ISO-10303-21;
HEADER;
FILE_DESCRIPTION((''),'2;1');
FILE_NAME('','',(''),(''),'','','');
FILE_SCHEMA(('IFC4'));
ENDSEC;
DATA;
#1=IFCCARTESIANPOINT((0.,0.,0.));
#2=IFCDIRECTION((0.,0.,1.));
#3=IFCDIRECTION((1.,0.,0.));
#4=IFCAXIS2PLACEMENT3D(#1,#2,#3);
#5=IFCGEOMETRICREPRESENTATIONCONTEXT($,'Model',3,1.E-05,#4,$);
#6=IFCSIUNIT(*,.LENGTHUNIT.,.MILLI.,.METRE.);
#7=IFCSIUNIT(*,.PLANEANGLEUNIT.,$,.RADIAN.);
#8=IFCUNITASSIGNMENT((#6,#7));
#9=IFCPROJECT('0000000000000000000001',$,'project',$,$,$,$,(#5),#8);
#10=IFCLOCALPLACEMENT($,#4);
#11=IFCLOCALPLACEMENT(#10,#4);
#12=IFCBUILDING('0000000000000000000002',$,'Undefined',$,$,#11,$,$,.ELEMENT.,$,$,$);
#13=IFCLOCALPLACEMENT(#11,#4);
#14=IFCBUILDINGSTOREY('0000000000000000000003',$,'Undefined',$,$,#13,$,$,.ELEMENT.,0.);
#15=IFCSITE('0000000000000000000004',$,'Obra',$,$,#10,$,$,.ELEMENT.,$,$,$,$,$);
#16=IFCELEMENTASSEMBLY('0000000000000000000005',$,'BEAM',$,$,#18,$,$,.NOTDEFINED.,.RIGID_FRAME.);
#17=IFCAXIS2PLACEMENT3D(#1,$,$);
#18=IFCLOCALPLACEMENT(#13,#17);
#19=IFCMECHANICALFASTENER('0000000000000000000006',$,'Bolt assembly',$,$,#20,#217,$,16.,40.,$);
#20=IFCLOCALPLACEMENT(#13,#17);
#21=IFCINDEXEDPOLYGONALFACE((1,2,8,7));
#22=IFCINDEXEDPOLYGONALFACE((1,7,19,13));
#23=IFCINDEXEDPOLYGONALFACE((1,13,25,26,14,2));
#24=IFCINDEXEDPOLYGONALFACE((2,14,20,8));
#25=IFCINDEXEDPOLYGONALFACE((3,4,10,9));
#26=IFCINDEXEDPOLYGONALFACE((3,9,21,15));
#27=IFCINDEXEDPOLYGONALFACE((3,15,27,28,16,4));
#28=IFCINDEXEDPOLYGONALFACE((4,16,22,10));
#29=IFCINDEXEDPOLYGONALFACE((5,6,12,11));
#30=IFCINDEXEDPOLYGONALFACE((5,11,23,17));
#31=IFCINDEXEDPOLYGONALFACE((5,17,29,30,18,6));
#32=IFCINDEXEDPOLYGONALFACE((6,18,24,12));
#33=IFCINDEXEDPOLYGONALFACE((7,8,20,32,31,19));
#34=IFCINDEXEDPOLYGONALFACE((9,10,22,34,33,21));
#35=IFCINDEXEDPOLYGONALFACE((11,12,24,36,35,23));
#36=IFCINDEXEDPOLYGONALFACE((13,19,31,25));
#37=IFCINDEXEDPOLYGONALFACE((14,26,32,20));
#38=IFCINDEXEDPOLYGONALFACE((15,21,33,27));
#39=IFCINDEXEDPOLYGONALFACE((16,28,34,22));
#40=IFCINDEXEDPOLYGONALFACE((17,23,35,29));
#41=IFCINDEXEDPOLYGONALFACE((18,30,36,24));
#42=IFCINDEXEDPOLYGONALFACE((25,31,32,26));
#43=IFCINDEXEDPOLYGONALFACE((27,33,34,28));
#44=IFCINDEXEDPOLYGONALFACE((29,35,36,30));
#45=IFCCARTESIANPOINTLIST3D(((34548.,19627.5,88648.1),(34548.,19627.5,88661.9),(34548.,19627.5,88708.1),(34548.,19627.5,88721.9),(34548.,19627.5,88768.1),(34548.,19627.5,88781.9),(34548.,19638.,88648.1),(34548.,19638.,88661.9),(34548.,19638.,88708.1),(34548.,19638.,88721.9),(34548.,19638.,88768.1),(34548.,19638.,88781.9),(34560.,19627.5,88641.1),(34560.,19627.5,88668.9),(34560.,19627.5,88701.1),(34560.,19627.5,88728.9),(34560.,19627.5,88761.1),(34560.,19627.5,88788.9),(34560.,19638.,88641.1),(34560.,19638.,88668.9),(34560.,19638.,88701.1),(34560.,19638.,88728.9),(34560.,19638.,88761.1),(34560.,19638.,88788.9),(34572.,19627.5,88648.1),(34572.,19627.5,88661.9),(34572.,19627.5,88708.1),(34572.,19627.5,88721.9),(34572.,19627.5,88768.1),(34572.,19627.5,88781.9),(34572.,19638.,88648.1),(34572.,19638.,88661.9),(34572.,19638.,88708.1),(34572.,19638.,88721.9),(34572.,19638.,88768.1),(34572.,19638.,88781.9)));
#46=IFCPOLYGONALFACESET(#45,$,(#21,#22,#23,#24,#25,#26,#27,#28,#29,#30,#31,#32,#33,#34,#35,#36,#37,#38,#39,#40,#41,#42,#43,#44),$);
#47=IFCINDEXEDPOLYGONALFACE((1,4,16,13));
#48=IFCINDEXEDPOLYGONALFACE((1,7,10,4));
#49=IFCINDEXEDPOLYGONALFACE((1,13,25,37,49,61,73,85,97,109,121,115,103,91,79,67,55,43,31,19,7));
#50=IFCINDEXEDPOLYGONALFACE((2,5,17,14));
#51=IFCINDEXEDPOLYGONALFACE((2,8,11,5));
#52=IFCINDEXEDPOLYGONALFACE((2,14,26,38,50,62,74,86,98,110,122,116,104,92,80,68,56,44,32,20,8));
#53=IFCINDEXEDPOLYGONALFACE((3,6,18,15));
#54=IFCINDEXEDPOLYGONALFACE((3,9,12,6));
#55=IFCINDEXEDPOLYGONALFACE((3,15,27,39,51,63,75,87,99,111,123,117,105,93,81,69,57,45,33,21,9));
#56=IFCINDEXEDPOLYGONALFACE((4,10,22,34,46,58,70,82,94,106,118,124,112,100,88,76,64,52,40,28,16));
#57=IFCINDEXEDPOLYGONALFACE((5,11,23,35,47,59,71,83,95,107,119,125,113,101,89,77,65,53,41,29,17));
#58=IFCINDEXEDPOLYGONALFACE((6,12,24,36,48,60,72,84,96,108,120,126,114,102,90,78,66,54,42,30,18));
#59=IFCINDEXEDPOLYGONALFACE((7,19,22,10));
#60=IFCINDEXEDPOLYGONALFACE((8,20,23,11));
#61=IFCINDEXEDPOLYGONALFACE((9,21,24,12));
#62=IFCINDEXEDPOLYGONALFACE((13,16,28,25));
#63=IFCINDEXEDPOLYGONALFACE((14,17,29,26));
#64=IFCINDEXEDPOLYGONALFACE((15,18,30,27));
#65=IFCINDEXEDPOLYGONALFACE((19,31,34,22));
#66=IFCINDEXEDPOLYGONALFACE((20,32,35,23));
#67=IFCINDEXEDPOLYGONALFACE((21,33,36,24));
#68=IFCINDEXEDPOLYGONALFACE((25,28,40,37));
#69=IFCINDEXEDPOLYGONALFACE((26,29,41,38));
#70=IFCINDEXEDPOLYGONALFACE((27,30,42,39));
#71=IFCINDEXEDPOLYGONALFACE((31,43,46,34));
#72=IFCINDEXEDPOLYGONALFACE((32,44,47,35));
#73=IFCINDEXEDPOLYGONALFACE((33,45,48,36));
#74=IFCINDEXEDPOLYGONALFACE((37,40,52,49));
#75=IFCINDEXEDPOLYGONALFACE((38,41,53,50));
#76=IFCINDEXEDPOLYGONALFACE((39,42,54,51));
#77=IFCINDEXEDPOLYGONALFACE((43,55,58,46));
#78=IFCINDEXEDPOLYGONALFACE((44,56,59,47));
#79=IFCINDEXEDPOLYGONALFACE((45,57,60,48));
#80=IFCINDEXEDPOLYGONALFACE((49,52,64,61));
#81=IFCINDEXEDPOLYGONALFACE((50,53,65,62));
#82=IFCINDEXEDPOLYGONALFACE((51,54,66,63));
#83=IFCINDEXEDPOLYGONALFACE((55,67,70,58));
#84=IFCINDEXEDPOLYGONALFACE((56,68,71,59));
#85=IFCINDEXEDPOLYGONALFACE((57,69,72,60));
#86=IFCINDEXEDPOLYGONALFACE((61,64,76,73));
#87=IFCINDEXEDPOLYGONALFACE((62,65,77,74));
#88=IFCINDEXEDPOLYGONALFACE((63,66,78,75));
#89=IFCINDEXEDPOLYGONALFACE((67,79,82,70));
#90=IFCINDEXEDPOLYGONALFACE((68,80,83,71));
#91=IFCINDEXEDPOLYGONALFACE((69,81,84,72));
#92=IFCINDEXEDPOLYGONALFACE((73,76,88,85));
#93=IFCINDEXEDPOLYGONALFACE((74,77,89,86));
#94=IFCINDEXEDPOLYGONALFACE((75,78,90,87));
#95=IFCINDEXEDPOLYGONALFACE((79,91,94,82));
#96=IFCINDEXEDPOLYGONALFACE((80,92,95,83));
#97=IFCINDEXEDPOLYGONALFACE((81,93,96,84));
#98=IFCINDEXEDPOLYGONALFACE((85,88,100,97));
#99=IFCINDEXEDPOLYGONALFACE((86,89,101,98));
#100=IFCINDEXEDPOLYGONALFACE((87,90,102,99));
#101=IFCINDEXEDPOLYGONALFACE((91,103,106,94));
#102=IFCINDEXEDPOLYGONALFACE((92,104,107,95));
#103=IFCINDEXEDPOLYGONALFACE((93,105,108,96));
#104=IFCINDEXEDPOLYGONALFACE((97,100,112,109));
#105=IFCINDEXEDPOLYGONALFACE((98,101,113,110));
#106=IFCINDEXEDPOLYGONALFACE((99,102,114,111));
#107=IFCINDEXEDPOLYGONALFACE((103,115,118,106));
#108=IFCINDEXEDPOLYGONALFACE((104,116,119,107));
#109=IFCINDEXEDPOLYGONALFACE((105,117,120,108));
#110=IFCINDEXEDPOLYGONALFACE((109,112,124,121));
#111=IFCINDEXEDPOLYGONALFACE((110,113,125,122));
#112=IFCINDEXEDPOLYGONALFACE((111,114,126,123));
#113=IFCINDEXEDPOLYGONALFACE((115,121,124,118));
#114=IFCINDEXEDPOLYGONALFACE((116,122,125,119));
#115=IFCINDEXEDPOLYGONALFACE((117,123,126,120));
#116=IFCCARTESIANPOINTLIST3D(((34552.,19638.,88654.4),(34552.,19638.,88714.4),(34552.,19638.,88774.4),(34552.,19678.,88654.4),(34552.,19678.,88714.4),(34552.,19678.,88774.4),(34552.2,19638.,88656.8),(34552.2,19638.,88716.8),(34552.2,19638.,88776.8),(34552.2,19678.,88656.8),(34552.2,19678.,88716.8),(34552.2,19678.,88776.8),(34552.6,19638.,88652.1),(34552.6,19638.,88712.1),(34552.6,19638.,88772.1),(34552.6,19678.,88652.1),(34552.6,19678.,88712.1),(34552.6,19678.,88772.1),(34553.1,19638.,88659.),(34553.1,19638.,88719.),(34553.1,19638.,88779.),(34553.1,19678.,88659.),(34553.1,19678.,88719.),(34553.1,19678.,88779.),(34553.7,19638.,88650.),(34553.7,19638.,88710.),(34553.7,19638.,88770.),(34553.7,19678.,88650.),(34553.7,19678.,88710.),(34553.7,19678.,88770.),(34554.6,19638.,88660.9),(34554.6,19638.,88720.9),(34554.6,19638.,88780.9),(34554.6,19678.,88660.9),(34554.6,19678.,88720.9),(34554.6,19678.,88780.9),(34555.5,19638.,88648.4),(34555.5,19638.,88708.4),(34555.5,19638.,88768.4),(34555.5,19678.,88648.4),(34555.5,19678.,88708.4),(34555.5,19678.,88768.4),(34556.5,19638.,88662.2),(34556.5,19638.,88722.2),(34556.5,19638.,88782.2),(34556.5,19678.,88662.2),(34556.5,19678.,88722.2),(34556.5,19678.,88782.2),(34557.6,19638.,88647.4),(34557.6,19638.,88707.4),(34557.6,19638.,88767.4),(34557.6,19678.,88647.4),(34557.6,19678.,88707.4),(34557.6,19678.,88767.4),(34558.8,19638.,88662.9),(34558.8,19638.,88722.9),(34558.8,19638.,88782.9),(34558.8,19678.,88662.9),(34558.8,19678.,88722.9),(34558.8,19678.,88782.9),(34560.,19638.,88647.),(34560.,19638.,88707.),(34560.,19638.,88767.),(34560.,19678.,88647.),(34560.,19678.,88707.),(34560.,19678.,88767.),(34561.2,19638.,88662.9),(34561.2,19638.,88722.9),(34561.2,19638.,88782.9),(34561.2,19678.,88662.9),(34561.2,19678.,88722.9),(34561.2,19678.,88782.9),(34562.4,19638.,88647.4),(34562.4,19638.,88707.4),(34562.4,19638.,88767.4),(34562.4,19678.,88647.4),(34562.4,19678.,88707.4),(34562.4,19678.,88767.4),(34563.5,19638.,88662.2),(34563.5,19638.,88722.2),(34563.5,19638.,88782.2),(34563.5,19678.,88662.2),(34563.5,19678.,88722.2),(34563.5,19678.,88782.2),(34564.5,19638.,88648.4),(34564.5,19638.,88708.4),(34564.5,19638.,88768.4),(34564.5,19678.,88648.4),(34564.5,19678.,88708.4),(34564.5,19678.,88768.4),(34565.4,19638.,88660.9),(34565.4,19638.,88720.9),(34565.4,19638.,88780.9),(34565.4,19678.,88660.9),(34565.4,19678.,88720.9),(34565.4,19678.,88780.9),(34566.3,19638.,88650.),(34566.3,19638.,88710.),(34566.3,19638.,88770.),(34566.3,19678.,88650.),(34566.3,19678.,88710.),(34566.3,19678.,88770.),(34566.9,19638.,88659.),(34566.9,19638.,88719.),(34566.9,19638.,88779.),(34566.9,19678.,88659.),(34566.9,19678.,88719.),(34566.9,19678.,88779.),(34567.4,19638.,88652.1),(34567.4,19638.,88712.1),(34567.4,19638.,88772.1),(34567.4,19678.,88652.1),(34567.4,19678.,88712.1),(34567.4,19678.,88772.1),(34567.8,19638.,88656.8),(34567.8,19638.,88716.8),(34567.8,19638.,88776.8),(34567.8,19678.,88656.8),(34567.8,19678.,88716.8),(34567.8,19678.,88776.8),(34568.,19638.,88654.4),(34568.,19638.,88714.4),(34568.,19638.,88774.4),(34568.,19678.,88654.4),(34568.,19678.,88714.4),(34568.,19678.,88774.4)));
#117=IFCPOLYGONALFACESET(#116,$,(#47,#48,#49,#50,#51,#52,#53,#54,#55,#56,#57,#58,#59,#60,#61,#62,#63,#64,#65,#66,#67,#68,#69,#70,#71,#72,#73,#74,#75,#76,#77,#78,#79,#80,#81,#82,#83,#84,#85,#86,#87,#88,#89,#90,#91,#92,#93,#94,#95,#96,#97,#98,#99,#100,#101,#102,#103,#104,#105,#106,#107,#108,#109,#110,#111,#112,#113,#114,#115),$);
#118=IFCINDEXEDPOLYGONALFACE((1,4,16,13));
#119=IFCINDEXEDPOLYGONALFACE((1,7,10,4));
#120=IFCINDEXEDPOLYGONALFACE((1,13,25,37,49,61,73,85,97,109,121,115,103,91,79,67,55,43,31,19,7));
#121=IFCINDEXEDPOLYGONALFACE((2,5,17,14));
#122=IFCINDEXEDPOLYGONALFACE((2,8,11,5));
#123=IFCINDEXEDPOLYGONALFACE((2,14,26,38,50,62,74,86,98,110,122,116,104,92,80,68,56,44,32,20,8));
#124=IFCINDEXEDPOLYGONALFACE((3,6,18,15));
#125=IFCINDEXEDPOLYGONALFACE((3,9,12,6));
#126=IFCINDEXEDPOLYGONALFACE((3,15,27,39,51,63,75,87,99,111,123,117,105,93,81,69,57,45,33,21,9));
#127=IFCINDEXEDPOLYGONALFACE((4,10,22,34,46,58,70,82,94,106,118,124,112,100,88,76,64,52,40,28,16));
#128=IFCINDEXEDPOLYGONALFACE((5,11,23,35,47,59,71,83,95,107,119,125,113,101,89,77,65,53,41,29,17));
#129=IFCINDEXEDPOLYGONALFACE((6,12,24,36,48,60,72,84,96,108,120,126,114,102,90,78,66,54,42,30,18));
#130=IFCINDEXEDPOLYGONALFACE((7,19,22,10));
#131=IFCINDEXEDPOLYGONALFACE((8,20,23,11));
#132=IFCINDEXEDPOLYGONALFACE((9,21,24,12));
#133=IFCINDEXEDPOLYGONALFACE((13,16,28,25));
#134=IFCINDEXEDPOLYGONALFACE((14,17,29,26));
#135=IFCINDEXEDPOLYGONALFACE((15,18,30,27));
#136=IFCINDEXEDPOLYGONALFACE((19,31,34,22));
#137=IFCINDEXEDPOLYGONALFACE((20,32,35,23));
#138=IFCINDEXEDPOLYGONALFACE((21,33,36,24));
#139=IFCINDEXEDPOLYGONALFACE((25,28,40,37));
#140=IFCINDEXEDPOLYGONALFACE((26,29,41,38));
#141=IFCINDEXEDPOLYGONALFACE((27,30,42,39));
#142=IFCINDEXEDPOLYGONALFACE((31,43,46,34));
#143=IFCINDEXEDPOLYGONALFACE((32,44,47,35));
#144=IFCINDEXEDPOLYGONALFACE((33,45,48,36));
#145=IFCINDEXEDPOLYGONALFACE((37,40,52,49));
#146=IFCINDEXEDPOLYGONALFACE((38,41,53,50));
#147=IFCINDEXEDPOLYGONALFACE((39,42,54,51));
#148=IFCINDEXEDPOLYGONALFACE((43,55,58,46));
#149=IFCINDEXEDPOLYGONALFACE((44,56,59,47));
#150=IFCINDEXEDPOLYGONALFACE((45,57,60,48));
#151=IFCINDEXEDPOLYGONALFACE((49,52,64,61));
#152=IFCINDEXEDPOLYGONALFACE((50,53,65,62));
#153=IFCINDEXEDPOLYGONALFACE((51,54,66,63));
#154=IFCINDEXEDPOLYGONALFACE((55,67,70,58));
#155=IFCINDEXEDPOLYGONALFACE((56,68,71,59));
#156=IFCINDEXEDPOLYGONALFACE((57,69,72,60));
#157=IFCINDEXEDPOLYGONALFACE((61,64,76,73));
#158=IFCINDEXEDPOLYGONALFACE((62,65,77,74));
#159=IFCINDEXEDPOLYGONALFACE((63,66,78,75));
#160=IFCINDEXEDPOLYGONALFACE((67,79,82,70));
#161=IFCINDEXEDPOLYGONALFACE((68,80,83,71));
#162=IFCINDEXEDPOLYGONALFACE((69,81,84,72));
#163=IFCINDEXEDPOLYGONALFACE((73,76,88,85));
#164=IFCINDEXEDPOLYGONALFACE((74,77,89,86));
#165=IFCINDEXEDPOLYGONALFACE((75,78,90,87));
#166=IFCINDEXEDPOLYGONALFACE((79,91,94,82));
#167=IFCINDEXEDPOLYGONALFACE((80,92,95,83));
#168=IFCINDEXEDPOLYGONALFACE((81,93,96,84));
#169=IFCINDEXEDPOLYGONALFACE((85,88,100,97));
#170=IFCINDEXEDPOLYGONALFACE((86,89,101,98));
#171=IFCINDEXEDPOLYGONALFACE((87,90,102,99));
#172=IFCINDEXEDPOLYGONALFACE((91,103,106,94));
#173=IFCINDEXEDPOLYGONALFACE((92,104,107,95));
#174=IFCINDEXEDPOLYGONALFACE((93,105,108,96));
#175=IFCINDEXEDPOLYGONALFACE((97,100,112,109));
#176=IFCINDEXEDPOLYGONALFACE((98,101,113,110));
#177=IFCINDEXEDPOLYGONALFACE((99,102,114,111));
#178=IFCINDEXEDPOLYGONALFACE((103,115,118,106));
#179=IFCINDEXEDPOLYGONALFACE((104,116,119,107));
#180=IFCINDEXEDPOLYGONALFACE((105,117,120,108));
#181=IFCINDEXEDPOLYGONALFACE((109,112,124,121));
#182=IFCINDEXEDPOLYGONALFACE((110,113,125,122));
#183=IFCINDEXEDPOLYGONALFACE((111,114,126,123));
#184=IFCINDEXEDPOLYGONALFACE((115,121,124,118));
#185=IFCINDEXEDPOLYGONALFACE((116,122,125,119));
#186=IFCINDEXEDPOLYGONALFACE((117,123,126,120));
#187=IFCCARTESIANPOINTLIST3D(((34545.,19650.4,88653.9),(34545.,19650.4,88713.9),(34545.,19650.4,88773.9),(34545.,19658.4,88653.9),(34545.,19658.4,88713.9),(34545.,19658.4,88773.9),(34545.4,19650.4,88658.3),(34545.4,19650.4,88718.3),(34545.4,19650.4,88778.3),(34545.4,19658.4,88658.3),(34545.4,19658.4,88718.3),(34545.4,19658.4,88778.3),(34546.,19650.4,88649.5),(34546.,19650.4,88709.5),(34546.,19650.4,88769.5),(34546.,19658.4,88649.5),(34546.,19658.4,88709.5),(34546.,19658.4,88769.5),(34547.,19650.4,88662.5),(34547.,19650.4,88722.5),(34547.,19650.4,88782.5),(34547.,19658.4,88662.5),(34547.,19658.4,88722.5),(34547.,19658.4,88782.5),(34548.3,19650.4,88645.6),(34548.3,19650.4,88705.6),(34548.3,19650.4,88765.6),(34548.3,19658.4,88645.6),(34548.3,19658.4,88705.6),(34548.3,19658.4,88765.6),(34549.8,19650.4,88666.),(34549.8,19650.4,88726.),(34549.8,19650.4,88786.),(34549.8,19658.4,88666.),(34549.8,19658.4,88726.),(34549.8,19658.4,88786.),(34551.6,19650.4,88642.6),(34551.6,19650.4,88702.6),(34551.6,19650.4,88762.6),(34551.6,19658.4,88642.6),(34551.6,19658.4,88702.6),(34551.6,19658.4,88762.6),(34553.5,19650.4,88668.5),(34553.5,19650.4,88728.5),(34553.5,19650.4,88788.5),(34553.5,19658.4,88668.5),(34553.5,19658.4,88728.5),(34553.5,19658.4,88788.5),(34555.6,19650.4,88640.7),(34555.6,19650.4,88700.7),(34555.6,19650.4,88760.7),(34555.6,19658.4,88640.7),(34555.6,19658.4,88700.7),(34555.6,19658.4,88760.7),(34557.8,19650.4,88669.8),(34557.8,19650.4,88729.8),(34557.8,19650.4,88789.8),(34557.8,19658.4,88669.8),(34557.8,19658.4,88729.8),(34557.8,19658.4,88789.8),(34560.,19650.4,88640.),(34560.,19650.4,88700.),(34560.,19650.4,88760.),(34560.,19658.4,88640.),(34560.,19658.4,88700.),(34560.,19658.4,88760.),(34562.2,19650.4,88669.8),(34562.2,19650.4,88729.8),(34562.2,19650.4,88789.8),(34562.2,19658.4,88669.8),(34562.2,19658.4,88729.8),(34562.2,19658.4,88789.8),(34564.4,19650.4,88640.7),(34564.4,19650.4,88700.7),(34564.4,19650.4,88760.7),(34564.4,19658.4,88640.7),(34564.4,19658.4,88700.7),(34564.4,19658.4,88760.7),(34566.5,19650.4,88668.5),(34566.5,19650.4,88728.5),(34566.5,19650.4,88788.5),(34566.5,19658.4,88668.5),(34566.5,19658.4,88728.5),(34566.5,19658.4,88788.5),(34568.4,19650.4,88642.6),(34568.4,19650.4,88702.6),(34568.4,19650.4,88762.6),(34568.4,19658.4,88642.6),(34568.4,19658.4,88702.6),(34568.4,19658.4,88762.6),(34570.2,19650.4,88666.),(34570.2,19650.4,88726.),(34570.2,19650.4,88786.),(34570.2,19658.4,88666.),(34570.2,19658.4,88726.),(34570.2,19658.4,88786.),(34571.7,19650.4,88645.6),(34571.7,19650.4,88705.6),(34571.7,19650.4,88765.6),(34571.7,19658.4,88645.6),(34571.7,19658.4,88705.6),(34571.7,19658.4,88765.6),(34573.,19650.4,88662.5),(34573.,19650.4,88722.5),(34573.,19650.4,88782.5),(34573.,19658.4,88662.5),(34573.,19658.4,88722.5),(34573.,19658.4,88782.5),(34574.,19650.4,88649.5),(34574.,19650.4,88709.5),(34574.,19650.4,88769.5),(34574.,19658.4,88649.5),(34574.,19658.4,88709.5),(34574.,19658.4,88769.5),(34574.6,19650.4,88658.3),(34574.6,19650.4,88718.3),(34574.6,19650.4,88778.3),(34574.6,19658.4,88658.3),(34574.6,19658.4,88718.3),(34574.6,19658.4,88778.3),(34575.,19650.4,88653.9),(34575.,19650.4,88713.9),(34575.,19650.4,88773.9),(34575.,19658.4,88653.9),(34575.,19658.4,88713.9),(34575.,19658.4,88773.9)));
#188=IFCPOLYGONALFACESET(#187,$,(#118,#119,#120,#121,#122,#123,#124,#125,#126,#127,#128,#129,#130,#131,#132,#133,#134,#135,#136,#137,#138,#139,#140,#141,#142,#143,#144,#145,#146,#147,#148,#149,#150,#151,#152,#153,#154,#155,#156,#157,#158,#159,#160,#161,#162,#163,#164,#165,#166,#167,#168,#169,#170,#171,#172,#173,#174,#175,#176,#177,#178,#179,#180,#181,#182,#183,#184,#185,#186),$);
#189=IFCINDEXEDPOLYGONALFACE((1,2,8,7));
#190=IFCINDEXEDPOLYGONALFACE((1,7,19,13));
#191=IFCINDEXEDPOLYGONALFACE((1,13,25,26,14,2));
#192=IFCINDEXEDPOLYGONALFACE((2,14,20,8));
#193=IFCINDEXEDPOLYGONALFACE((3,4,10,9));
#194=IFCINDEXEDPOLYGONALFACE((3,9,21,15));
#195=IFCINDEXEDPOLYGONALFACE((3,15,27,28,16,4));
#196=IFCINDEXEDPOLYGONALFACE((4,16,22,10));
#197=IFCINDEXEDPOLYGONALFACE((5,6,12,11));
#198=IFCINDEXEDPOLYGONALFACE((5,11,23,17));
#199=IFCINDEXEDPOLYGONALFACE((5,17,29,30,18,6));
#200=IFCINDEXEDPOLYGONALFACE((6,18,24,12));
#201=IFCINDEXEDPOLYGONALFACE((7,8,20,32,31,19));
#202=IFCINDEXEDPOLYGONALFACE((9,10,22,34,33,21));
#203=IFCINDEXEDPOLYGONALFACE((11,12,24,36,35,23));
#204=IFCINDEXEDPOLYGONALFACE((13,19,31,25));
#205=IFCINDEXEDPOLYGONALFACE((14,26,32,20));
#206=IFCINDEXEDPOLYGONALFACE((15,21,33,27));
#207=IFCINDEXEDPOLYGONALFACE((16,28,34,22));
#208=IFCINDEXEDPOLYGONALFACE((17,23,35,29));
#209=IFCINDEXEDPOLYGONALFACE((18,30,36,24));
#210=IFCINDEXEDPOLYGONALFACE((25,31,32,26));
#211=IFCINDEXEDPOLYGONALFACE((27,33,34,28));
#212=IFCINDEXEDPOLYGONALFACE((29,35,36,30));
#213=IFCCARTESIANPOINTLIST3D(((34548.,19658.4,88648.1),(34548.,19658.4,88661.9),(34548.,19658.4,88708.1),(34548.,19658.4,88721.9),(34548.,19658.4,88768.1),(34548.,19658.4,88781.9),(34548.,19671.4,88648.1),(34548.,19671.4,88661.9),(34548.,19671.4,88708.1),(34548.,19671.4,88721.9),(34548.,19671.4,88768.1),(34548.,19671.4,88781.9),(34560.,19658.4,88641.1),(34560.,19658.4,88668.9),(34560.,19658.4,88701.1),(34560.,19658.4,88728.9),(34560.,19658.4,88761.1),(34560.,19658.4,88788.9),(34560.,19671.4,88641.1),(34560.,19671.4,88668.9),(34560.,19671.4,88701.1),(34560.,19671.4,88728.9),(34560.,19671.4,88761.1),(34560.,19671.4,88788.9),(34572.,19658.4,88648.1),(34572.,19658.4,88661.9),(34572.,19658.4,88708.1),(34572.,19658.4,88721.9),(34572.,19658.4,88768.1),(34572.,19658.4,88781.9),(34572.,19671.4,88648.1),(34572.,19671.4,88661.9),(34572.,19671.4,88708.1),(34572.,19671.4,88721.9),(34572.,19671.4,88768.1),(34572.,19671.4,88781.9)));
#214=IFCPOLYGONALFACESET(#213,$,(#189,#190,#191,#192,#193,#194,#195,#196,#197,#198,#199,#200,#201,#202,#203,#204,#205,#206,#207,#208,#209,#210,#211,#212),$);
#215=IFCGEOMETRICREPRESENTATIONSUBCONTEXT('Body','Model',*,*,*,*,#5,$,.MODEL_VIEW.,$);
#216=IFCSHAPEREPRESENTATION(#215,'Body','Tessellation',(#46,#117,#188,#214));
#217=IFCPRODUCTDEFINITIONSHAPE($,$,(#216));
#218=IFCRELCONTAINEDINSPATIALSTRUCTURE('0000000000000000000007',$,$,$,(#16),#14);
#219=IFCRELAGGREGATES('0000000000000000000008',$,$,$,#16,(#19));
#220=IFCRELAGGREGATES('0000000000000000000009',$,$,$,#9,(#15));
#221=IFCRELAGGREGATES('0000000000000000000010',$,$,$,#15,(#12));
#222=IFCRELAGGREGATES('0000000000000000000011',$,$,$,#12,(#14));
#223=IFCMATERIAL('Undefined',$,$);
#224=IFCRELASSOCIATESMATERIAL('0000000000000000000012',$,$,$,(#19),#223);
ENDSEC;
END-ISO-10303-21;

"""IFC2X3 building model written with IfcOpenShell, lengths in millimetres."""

from ifc_helpers import new_model, si_unit, frame, origin_with_axes, origin_2d_with_axis, place, context, subcontext, project, spatial, polyline, circle, outline, extrude, source, transform, mapped, material, element, aggregate, save


model = new_model("IFC2X3")

# Units and contexts
model_context = context("Model", 3, precision=1e-05, world=origin_with_axes())
body_context = subcontext(model_context, "Body", "Model", "MODEL_VIEW")
ifc_project = project(units=[si_unit("LENGTHUNIT", "METRE", prefix="MILLI"), si_unit("PLANEANGLEUNIT", "RADIAN")], contexts=[model_context])

# Site, building, storey
site_placement = place(None, origin_with_axes())
site = spatial("IfcSite", under=ifc_project, at=site_placement, Name="Obra", CompositionType="ELEMENT")
building_placement = place(site_placement, origin_with_axes())
building = spatial("IfcBuilding", under=site, at=building_placement, Name="Undefined", CompositionType="ELEMENT")
storey_placement = place(building_placement, origin_with_axes())
storey = spatial("IfcBuildingStorey", under=building, at=storey_placement, Name="Undefined", CompositionType="ELEMENT", Elevation=0.0)

# Element assembly, mechanical fastener
assembly_1_placement = place(storey_placement, origin_with_axes())
assembly_1 = element("IfcElementAssembly", 1, at=assembly_1_placement, inside=storey, Name="BEAM", AssemblyPlace="NOTDEFINED", PredefinedType="RIGID_FRAME")
ifc_material_1 = material(Name="Undefined")
shared_shape_1 = source(origin_with_axes(), body_context, "Body", "SweptSolid", [
    extrude(outline(polyline([(13.9, 0.0), (6.9, 12.0), (-6.9, 12.0), (-13.9, 0.0), (-6.9, -12.0), (6.9, -12.0), (13.9, 0.0)])), frame((0.0, -19.7, 0.0), z_axis=(0.0, 1.0, 0.0), x_axis=(1.0, 0.0, 0.0)), (0.0, 0.0, 1.0), 10.6),
    extrude(circle(Radius=8.0, at=origin_2d_with_axis()), frame((0.0, -9.1, 0.0), z_axis=(0.0, 1.0, 0.0), x_axis=(1.0, 0.0, 0.0)), (0.0, 0.0, 1.0), 40.0),
    extrude(circle(Radius=15.0, at=origin_2d_with_axis()), frame((0.0, 3.3, 0.0), z_axis=(0.0, 1.0, 0.0), x_axis=(1.0, 0.0, 0.0)), (0.0, 0.0, 1.0), 8.0),
    extrude(outline(polyline([(13.9, 0.0), (6.9, 12.0), (-6.9, 12.0), (-13.9, 0.0), (-6.9, -12.0), (6.9, -12.0), (13.9, 0.0)])), frame((0.0, 11.3, 0.0), z_axis=(0.0, 1.0, 0.0), x_axis=(1.0, 0.0, 0.0)), (0.0, 0.0, 1.0), 13.0),
])
mechanical_fastener_1_placement = place(assembly_1_placement, frame((34510.0, 19647.1, 88835.0), z_axis=(1.0, 0.0, 0.0), x_axis=(0.0, 0.0, -1.0)))
mechanical_fastener_1 = element("IfcMechanicalFastener", 2, at=mechanical_fastener_1_placement, material=ifc_material_1, Name="Bolt assembly", NominalDiameter=16.0, NominalLength=40.0, context=body_context, shape_type="MappedRepresentation", body=[
    mapped(shared_shape_1, transform((60.0, 0.0, 50.0))),
    mapped(shared_shape_1, transform((120.0, 0.0, 50.0))),
    mapped(shared_shape_1, transform((180.0, 0.0, 50.0))),
])
aggregate(assembly_1, [mechanical_fastener_1])

save(model, "model.ifc")
